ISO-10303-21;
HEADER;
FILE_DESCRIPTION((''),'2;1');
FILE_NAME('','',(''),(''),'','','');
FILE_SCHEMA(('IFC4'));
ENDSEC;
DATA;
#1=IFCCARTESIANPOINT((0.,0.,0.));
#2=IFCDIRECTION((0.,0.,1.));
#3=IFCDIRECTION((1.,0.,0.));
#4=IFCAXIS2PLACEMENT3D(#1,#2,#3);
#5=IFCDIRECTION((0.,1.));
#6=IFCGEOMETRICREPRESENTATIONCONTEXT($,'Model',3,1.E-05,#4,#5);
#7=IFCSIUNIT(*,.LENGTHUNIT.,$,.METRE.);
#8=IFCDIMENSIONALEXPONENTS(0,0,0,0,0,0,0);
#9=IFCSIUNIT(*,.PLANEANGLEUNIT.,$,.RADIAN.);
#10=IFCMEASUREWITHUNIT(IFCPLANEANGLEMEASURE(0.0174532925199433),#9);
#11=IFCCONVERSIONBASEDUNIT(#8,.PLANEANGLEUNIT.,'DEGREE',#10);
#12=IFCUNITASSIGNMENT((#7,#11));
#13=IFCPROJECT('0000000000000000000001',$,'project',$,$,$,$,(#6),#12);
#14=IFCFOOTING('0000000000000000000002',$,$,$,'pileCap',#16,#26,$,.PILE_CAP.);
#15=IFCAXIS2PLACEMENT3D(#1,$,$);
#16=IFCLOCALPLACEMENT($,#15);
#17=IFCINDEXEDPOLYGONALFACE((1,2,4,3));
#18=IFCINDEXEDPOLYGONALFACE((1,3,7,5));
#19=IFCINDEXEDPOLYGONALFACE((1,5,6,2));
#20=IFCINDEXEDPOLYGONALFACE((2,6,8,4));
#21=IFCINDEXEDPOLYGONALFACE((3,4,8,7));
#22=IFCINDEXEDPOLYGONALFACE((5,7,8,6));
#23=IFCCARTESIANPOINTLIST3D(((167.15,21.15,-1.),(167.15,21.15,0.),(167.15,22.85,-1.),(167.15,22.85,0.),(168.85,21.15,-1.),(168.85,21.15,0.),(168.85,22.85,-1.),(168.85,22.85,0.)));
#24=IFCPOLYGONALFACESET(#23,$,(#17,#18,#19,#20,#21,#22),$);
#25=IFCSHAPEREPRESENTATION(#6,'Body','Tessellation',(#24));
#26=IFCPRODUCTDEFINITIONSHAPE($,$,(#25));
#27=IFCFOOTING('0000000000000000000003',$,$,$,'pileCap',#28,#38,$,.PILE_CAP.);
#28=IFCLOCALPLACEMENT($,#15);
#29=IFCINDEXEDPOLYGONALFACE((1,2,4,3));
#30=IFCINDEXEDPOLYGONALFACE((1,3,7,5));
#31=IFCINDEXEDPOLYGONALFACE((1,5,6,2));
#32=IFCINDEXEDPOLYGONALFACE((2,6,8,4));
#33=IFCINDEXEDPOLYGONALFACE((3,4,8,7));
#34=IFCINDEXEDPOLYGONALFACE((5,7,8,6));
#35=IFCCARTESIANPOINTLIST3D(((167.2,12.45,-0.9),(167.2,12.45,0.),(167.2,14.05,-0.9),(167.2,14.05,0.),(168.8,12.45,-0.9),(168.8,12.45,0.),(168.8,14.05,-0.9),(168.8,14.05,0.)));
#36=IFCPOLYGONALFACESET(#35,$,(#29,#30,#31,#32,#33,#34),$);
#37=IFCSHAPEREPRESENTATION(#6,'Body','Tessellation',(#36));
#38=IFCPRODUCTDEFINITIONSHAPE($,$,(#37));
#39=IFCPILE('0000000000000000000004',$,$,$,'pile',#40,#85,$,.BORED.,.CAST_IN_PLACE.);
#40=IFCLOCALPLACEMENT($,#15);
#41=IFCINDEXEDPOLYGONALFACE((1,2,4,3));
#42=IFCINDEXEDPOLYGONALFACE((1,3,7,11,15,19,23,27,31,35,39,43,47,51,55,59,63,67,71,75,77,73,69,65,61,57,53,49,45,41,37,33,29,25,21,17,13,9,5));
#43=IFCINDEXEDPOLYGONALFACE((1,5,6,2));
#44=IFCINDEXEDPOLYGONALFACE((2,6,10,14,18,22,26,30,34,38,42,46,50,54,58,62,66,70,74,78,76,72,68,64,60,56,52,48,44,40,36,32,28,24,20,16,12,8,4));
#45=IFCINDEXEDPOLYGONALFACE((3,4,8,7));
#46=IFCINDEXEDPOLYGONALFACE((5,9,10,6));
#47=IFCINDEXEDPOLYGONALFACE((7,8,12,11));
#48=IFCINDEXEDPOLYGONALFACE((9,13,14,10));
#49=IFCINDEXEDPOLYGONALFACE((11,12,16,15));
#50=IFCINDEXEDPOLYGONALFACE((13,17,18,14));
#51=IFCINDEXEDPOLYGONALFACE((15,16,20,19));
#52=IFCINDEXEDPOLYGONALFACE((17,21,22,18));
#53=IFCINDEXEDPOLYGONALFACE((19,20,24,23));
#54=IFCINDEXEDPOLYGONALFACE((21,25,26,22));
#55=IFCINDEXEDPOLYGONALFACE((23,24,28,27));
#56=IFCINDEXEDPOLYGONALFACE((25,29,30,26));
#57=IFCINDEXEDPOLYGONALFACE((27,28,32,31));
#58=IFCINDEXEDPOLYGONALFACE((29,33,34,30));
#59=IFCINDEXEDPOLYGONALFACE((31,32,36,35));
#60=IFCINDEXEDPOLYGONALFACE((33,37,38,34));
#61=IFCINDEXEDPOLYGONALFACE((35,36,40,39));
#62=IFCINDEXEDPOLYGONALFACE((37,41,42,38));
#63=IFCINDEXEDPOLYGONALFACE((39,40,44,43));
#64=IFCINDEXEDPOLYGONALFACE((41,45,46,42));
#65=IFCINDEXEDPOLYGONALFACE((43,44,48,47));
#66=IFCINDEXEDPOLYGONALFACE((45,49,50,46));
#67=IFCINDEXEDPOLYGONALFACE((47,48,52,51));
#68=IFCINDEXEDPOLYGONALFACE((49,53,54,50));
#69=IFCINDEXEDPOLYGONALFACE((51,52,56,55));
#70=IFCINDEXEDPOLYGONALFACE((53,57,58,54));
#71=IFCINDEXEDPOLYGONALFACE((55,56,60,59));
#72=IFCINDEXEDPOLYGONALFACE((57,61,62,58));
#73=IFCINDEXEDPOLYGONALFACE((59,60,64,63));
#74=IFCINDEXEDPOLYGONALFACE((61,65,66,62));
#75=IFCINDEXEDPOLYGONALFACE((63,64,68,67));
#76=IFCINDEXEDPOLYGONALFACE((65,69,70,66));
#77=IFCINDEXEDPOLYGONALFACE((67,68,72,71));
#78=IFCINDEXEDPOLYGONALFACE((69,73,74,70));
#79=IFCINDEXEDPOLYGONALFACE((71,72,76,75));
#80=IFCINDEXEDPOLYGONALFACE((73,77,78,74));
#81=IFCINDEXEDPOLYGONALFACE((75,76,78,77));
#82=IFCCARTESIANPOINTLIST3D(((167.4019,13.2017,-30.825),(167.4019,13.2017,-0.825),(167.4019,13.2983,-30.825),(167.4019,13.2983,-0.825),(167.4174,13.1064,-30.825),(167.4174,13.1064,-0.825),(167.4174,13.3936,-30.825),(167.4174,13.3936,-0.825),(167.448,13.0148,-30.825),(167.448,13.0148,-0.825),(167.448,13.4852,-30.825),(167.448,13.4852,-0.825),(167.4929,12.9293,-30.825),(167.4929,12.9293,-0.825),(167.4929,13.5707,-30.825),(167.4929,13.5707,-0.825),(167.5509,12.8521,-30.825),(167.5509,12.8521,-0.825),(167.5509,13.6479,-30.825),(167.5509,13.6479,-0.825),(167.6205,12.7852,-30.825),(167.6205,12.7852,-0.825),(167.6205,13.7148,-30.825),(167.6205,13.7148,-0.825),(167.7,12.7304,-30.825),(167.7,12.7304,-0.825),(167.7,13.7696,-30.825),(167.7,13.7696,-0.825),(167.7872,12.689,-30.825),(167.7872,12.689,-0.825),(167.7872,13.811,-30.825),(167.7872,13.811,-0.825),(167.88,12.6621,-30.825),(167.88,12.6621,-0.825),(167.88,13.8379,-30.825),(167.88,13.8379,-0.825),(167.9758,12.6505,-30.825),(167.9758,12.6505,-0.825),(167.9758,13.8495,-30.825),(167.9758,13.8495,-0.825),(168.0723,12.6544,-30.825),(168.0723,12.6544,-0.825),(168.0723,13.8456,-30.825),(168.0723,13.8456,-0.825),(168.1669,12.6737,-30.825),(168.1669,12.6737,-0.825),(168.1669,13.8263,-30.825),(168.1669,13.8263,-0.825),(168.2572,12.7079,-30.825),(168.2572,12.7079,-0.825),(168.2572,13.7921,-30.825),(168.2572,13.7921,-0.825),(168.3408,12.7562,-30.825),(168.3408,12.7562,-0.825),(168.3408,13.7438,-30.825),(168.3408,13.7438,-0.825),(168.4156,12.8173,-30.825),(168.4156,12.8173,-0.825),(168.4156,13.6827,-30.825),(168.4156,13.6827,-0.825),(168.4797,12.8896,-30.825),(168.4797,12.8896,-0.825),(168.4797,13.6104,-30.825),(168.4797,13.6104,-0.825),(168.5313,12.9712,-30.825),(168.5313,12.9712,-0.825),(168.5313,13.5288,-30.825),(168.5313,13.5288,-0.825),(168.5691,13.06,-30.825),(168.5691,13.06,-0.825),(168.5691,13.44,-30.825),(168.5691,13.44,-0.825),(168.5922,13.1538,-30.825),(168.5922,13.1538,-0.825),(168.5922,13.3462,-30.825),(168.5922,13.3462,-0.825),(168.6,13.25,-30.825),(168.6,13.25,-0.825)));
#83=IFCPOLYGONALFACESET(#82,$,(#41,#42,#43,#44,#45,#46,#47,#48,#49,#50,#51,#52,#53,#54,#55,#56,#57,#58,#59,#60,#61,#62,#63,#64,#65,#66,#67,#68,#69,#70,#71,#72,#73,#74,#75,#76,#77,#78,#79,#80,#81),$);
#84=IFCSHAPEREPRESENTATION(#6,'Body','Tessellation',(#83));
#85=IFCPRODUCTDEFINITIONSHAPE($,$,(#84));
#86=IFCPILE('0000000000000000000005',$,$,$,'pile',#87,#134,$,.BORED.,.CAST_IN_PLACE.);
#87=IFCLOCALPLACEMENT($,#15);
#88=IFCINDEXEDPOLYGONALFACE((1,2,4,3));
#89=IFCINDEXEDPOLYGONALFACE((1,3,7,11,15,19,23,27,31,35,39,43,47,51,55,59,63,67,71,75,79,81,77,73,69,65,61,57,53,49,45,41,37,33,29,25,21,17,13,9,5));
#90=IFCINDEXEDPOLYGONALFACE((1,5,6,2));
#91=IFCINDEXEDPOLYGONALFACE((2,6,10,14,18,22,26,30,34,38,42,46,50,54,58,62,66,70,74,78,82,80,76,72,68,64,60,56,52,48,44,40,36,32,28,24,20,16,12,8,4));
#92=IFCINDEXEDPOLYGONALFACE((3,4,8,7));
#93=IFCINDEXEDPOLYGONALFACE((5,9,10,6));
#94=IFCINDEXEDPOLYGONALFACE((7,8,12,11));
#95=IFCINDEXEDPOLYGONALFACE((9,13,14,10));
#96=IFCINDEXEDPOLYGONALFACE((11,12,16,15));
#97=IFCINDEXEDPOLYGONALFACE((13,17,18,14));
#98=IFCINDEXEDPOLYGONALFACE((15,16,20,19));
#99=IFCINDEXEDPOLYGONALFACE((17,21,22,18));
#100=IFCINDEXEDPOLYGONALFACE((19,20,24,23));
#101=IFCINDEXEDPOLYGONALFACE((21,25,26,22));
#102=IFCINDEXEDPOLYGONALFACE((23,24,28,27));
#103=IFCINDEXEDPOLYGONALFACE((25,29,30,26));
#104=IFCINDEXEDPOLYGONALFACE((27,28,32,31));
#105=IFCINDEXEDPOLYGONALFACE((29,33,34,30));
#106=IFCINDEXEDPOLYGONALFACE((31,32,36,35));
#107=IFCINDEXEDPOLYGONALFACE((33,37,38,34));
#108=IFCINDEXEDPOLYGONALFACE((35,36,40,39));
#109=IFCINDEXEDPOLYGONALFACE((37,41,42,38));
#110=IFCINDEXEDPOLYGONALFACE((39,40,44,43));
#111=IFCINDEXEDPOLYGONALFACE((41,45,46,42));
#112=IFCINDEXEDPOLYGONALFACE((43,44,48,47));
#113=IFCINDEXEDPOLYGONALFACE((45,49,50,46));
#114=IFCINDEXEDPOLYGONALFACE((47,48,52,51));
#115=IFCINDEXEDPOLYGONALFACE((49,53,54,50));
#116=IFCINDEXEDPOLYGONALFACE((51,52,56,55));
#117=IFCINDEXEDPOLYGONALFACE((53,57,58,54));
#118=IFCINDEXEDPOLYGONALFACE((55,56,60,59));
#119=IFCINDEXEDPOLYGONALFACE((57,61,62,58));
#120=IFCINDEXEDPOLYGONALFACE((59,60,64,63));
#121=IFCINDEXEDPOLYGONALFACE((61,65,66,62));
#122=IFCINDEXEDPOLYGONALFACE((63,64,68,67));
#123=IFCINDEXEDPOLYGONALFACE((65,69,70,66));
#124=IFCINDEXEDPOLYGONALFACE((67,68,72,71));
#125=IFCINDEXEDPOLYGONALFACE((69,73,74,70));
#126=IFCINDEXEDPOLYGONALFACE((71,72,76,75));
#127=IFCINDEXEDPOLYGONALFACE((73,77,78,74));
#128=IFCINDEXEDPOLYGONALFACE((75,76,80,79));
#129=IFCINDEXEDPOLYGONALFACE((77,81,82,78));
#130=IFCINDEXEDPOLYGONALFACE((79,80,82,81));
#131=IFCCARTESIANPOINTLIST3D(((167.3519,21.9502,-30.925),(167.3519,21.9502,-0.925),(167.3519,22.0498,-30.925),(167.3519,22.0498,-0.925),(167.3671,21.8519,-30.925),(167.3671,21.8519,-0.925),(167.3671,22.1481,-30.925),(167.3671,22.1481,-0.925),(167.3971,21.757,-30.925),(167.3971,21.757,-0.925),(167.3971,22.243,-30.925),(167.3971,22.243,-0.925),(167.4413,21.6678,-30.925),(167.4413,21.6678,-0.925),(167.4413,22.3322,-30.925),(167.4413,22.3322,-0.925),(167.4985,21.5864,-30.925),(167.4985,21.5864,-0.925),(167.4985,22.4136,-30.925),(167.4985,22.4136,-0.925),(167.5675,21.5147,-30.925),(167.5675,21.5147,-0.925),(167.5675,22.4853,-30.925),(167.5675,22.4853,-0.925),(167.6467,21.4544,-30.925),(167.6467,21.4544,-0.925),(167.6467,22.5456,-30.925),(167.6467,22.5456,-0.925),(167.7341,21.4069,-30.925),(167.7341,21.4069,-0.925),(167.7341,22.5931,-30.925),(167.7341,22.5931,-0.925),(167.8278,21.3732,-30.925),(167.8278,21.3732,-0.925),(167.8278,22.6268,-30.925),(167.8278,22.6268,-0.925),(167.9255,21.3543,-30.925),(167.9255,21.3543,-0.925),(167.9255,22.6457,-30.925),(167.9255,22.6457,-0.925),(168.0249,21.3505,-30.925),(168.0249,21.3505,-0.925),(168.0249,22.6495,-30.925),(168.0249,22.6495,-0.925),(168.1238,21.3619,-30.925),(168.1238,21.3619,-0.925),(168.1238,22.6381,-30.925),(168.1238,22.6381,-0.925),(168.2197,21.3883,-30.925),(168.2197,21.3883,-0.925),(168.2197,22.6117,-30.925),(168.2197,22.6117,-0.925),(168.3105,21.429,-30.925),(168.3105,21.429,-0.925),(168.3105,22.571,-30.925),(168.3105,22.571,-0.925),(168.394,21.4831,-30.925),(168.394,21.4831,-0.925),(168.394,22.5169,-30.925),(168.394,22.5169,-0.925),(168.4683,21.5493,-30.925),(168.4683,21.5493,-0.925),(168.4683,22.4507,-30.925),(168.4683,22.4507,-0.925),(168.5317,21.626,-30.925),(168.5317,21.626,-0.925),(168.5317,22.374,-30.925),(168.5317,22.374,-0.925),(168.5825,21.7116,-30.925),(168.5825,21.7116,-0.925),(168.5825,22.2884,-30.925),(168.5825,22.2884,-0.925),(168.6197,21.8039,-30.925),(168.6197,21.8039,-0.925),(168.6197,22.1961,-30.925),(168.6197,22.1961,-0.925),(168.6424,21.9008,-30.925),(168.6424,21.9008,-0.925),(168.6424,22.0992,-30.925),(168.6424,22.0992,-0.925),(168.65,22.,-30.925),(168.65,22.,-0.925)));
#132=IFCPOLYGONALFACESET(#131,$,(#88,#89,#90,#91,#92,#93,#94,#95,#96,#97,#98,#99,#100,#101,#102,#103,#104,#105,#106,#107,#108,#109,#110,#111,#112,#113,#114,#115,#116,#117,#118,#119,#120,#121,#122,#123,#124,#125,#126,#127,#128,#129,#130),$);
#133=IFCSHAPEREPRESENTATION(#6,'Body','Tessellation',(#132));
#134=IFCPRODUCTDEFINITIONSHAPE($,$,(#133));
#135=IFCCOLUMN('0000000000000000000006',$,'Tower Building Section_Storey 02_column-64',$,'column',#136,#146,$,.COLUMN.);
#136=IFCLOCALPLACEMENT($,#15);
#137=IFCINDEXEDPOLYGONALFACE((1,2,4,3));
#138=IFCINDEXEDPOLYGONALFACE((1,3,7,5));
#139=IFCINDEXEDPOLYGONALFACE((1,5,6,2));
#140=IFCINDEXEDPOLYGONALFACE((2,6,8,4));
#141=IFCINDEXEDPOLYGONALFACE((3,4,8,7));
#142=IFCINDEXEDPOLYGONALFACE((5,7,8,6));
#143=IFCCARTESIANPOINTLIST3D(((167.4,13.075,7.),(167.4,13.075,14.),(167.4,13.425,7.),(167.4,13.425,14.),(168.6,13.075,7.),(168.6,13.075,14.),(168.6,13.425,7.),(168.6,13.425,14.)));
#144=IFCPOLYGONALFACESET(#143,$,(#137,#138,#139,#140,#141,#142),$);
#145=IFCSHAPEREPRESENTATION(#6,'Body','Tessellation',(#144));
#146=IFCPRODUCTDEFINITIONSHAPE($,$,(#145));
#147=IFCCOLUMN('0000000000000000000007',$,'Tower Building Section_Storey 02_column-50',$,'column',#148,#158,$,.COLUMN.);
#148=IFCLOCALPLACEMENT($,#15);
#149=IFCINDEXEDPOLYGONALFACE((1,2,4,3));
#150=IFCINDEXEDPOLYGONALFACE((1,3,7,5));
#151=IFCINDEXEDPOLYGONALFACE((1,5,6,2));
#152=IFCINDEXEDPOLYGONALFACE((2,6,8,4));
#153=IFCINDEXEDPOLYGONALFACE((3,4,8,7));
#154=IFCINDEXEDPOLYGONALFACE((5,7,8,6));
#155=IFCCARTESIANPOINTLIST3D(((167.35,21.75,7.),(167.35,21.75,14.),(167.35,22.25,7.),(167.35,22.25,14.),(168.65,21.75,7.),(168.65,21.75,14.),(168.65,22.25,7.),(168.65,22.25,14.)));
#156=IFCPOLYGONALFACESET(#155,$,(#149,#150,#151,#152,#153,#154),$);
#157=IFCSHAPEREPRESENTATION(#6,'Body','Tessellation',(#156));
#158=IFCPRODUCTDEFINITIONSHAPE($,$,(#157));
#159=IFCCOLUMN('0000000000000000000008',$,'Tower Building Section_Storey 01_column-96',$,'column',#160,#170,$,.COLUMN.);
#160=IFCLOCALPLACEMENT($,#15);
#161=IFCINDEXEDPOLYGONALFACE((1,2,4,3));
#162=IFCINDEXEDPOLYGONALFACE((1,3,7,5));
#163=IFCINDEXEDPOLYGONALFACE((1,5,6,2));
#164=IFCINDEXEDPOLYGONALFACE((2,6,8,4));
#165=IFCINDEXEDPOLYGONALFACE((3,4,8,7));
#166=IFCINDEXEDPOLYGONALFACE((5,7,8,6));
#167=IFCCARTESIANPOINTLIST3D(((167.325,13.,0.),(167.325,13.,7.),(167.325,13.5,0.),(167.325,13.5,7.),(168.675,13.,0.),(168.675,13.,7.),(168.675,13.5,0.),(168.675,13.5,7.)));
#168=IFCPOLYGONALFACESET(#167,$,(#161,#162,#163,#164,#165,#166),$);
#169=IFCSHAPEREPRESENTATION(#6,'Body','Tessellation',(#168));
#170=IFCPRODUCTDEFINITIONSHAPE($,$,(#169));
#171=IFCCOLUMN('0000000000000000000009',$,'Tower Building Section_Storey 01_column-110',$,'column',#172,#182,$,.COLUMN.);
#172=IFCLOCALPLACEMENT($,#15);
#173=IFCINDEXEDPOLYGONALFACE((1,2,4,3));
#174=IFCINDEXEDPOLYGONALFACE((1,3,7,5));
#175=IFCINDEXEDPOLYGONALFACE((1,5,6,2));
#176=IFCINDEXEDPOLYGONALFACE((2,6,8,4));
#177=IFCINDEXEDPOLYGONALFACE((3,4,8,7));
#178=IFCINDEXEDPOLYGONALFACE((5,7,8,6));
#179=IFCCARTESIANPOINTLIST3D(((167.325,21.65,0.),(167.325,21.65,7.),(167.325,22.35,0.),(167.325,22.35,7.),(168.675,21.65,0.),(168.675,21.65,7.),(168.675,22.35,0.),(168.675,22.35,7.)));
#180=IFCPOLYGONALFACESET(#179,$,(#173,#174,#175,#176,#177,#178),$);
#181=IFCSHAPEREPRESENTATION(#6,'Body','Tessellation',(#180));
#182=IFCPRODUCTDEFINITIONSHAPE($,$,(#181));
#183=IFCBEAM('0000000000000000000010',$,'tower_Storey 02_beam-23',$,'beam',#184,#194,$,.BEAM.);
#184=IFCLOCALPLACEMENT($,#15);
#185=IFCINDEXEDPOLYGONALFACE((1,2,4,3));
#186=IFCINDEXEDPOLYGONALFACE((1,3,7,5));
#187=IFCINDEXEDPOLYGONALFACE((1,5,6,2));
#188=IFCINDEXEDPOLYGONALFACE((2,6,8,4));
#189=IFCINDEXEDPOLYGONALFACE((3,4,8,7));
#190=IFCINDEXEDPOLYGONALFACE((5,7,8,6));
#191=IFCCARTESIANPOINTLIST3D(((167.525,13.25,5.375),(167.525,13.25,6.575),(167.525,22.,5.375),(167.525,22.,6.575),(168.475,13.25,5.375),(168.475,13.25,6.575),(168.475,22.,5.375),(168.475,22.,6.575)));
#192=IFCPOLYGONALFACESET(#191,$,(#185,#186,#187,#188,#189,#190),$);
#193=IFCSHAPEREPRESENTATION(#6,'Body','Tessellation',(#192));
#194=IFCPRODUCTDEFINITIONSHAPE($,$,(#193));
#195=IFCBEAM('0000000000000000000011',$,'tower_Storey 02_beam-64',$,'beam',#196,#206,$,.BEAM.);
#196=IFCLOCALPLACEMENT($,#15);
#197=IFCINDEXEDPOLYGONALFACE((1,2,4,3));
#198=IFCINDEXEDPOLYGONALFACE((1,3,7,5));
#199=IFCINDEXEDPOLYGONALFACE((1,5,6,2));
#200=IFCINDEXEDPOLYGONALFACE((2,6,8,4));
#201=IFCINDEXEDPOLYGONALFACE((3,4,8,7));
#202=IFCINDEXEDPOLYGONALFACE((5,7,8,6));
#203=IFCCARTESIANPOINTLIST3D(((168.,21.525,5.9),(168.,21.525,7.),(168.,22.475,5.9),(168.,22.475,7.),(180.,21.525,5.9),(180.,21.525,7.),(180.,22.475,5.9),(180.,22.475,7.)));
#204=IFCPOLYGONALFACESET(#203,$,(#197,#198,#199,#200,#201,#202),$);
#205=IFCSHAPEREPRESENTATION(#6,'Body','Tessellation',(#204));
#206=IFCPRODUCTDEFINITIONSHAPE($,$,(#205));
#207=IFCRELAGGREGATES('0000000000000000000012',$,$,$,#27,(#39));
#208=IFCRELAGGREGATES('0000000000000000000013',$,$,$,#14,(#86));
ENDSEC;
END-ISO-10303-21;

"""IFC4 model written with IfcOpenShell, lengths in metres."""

from ifc_helpers import new_model, entity, si_unit, converted_unit, direction, frame, origin_with_axes, place, context, project, polyline, circle_curve, parameter, trimmed, segment, composite_curve, outline, extrude, element, aggregate, save


model = new_model("IFC4")

# Units and contexts
model_context = context("Model", 3, precision=1e-05, world=origin_with_axes(), true_north=direction((0.0, 1.0)))
ifc_project = project(units=[si_unit("LENGTHUNIT", "METRE"), converted_unit("PLANEANGLEUNIT", "DEGREE", entity("IfcPlaneAngleMeasure", 0.0174532925199433), si_unit("PLANEANGLEUNIT", "RADIAN"), dimensions=[0, 0, 0, 0, 0, 0, 0])], contexts=[model_context])

# Footing
placement_1 = place(None, origin_with_axes())
placement_2 = place(placement_1, origin_with_axes())
footing_1_placement = place(placement_2, frame((168.0, 22.0, -1.0), z_axis=(0.0, 0.0, 1.0), x_axis=(1.0, 0.0, 0.0)))
footing_1 = element("IfcFooting", 1, at=footing_1_placement, ObjectType="pileCap", PredefinedType="PILE_CAP", context=model_context, body=[
    extrude(outline(polyline([(0.85, -0.85, 0.0), (0.85, 0.85, 0.0), (-0.85, 0.85, 0.0), (-0.85, -0.85, 0.0), (0.85, -0.85, 0.0)])), origin_with_axes(), (0.0, 0.0, 1.0), 1.0),
])

# Footing, pile
footing_2_placement = place(placement_2, frame((168.0, 13.25, -0.9), z_axis=(0.0, 0.0, 1.0), x_axis=(1.0, 0.0, 0.0)))
footing_2 = element("IfcFooting", 2, at=footing_2_placement, ObjectType="pileCap", PredefinedType="PILE_CAP", context=model_context, body=[
    extrude(outline(polyline([(0.8, -0.8, 0.0), (0.8, 0.8, 0.0), (-0.8, 0.8, 0.0), (-0.8, -0.8, 0.0), (0.8, -0.8, 0.0)])), origin_with_axes(), (0.0, 0.0, 1.0), 0.9),
])
pile_1_placement = place(footing_2_placement, frame((0.0, 0.0, -29.925), z_axis=(0.0, 0.0, 1.0), x_axis=(1.0, 0.0, 0.0)))
pile_1 = element("IfcPile", 3, at=pile_1_placement, ObjectType="pile", ConstructionType="CAST_IN_PLACE", PredefinedType="BORED", context=model_context, body=[
    extrude(outline(composite_curve([segment(trimmed(circle_curve(origin_with_axes(), 0.6), [parameter(0.0)], [parameter(360.0)], True, "PARAMETER"), True, "CONTINUOUS")], self_intersect=False)), origin_with_axes(), (0.0, 0.0, 1.0), 30.0),
])
aggregate(footing_2, [pile_1])

# Pile
pile_2_placement = place(footing_1_placement, frame((0.0, 0.0, -29.925), z_axis=(0.0, 0.0, 1.0), x_axis=(1.0, 0.0, 0.0)))
pile_2 = element("IfcPile", 4, at=pile_2_placement, ObjectType="pile", ConstructionType="CAST_IN_PLACE", PredefinedType="BORED", context=model_context, body=[
    extrude(outline(composite_curve([segment(trimmed(circle_curve(origin_with_axes(), 0.65), [parameter(0.0)], [parameter(360.0)], True, "PARAMETER"), True, "CONTINUOUS")], self_intersect=False)), origin_with_axes(), (0.0, 0.0, 1.0), 30.0),
])
aggregate(footing_1, [pile_2])

# Columns
placement_3 = place(placement_1, frame((0.0, 0.0, 7.0), z_axis=(0.0, 0.0, 1.0), x_axis=(1.0, 0.0, 0.0)))
column_1_placement = place(placement_3, frame((168.0, 13.25, 0.0), z_axis=(0.0, 0.0, 1.0), x_axis=(1.0, 0.0, 0.0)))
element("IfcColumn", 5, at=column_1_placement, Name="Tower Building Section_Storey 02_column-64", ObjectType="column", PredefinedType="COLUMN", context=model_context, body=[
    extrude(outline(polyline([(-0.6, -0.175, 0.0), (0.6, -0.175, 0.0), (0.6, 0.175, 0.0), (-0.6, 0.175, 0.0), (-0.6, -0.175, 0.0)])), origin_with_axes(), (0.0, 0.0, 1.0), 7.0),
])
column_2_placement = place(placement_3, frame((168.0, 22.0, 0.0), z_axis=(0.0, 0.0, 1.0), x_axis=(1.0, 0.0, 0.0)))
element("IfcColumn", 6, at=column_2_placement, Name="Tower Building Section_Storey 02_column-50", ObjectType="column", PredefinedType="COLUMN", context=model_context, body=[
    extrude(outline(polyline([(-0.65, -0.25, 0.0), (0.65, -0.25, 0.0), (0.65, 0.25, 0.0), (-0.65, 0.25, 0.0), (-0.65, -0.25, 0.0)])), origin_with_axes(), (0.0, 0.0, 1.0), 7.0),
])
column_3_placement = place(placement_2, frame((168.0, 13.25, 0.0), z_axis=(0.0, 0.0, 1.0), x_axis=(1.0, 0.0, 0.0)))
element("IfcColumn", 7, at=column_3_placement, Name="Tower Building Section_Storey 01_column-96", ObjectType="column", PredefinedType="COLUMN", context=model_context, body=[
    extrude(outline(polyline([(-0.675, -0.25, 0.0), (0.675, -0.25, 0.0), (0.675, 0.25, 0.0), (-0.675, 0.25, 0.0), (-0.675, -0.25, 0.0)])), origin_with_axes(), (0.0, 0.0, 1.0), 7.0),
])
column_4_placement = place(placement_2, frame((168.0, 22.0, 0.0), z_axis=(0.0, 0.0, 1.0), x_axis=(1.0, 0.0, 0.0)))
element("IfcColumn", 8, at=column_4_placement, Name="Tower Building Section_Storey 01_column-110", ObjectType="column", PredefinedType="COLUMN", context=model_context, body=[
    extrude(outline(polyline([(-0.675, -0.35, 0.0), (0.675, -0.35, 0.0), (0.675, 0.35, 0.0), (-0.675, 0.35, 0.0), (-0.675, -0.35, 0.0)])), origin_with_axes(), (0.0, 0.0, 1.0), 7.0),
])

# Beams
beam_1_placement = place(placement_3, frame((168.0, 13.25, -1.025), z_axis=(0.0, 1.0, 0.0), x_axis=(-1.0, 0.0, 0.0)))
element("IfcBeam", 9, at=beam_1_placement, Name="tower_Storey 02_beam-23", ObjectType="beam", PredefinedType="BEAM", context=model_context, body=[
    extrude(outline(polyline([(0.475, 0.6, 0.0), (-0.475, 0.6, 0.0), (-0.475, -0.6, 0.0), (0.475, -0.6, 0.0), (0.475, 0.6, 0.0)])), origin_with_axes(), (0.0, 0.0, 1.0), 8.75),
])
beam_2_placement = place(placement_3, frame((168.0, 22.0, -0.55), z_axis=(1.0, 0.0, 0.0), x_axis=(0.0, 1.0, 0.0)))
element("IfcBeam", 10, at=beam_2_placement, Name="tower_Storey 02_beam-64", ObjectType="beam", PredefinedType="BEAM", context=model_context, body=[
    extrude(outline(polyline([(0.475, 0.55, 0.0), (-0.475, 0.55, 0.0), (-0.475, -0.55, 0.0), (0.475, -0.55, 0.0), (0.475, 0.55, 0.0)])), origin_with_axes(), (0.0, 0.0, 1.0), 12.0),
])

save(model, "model.ifc")
